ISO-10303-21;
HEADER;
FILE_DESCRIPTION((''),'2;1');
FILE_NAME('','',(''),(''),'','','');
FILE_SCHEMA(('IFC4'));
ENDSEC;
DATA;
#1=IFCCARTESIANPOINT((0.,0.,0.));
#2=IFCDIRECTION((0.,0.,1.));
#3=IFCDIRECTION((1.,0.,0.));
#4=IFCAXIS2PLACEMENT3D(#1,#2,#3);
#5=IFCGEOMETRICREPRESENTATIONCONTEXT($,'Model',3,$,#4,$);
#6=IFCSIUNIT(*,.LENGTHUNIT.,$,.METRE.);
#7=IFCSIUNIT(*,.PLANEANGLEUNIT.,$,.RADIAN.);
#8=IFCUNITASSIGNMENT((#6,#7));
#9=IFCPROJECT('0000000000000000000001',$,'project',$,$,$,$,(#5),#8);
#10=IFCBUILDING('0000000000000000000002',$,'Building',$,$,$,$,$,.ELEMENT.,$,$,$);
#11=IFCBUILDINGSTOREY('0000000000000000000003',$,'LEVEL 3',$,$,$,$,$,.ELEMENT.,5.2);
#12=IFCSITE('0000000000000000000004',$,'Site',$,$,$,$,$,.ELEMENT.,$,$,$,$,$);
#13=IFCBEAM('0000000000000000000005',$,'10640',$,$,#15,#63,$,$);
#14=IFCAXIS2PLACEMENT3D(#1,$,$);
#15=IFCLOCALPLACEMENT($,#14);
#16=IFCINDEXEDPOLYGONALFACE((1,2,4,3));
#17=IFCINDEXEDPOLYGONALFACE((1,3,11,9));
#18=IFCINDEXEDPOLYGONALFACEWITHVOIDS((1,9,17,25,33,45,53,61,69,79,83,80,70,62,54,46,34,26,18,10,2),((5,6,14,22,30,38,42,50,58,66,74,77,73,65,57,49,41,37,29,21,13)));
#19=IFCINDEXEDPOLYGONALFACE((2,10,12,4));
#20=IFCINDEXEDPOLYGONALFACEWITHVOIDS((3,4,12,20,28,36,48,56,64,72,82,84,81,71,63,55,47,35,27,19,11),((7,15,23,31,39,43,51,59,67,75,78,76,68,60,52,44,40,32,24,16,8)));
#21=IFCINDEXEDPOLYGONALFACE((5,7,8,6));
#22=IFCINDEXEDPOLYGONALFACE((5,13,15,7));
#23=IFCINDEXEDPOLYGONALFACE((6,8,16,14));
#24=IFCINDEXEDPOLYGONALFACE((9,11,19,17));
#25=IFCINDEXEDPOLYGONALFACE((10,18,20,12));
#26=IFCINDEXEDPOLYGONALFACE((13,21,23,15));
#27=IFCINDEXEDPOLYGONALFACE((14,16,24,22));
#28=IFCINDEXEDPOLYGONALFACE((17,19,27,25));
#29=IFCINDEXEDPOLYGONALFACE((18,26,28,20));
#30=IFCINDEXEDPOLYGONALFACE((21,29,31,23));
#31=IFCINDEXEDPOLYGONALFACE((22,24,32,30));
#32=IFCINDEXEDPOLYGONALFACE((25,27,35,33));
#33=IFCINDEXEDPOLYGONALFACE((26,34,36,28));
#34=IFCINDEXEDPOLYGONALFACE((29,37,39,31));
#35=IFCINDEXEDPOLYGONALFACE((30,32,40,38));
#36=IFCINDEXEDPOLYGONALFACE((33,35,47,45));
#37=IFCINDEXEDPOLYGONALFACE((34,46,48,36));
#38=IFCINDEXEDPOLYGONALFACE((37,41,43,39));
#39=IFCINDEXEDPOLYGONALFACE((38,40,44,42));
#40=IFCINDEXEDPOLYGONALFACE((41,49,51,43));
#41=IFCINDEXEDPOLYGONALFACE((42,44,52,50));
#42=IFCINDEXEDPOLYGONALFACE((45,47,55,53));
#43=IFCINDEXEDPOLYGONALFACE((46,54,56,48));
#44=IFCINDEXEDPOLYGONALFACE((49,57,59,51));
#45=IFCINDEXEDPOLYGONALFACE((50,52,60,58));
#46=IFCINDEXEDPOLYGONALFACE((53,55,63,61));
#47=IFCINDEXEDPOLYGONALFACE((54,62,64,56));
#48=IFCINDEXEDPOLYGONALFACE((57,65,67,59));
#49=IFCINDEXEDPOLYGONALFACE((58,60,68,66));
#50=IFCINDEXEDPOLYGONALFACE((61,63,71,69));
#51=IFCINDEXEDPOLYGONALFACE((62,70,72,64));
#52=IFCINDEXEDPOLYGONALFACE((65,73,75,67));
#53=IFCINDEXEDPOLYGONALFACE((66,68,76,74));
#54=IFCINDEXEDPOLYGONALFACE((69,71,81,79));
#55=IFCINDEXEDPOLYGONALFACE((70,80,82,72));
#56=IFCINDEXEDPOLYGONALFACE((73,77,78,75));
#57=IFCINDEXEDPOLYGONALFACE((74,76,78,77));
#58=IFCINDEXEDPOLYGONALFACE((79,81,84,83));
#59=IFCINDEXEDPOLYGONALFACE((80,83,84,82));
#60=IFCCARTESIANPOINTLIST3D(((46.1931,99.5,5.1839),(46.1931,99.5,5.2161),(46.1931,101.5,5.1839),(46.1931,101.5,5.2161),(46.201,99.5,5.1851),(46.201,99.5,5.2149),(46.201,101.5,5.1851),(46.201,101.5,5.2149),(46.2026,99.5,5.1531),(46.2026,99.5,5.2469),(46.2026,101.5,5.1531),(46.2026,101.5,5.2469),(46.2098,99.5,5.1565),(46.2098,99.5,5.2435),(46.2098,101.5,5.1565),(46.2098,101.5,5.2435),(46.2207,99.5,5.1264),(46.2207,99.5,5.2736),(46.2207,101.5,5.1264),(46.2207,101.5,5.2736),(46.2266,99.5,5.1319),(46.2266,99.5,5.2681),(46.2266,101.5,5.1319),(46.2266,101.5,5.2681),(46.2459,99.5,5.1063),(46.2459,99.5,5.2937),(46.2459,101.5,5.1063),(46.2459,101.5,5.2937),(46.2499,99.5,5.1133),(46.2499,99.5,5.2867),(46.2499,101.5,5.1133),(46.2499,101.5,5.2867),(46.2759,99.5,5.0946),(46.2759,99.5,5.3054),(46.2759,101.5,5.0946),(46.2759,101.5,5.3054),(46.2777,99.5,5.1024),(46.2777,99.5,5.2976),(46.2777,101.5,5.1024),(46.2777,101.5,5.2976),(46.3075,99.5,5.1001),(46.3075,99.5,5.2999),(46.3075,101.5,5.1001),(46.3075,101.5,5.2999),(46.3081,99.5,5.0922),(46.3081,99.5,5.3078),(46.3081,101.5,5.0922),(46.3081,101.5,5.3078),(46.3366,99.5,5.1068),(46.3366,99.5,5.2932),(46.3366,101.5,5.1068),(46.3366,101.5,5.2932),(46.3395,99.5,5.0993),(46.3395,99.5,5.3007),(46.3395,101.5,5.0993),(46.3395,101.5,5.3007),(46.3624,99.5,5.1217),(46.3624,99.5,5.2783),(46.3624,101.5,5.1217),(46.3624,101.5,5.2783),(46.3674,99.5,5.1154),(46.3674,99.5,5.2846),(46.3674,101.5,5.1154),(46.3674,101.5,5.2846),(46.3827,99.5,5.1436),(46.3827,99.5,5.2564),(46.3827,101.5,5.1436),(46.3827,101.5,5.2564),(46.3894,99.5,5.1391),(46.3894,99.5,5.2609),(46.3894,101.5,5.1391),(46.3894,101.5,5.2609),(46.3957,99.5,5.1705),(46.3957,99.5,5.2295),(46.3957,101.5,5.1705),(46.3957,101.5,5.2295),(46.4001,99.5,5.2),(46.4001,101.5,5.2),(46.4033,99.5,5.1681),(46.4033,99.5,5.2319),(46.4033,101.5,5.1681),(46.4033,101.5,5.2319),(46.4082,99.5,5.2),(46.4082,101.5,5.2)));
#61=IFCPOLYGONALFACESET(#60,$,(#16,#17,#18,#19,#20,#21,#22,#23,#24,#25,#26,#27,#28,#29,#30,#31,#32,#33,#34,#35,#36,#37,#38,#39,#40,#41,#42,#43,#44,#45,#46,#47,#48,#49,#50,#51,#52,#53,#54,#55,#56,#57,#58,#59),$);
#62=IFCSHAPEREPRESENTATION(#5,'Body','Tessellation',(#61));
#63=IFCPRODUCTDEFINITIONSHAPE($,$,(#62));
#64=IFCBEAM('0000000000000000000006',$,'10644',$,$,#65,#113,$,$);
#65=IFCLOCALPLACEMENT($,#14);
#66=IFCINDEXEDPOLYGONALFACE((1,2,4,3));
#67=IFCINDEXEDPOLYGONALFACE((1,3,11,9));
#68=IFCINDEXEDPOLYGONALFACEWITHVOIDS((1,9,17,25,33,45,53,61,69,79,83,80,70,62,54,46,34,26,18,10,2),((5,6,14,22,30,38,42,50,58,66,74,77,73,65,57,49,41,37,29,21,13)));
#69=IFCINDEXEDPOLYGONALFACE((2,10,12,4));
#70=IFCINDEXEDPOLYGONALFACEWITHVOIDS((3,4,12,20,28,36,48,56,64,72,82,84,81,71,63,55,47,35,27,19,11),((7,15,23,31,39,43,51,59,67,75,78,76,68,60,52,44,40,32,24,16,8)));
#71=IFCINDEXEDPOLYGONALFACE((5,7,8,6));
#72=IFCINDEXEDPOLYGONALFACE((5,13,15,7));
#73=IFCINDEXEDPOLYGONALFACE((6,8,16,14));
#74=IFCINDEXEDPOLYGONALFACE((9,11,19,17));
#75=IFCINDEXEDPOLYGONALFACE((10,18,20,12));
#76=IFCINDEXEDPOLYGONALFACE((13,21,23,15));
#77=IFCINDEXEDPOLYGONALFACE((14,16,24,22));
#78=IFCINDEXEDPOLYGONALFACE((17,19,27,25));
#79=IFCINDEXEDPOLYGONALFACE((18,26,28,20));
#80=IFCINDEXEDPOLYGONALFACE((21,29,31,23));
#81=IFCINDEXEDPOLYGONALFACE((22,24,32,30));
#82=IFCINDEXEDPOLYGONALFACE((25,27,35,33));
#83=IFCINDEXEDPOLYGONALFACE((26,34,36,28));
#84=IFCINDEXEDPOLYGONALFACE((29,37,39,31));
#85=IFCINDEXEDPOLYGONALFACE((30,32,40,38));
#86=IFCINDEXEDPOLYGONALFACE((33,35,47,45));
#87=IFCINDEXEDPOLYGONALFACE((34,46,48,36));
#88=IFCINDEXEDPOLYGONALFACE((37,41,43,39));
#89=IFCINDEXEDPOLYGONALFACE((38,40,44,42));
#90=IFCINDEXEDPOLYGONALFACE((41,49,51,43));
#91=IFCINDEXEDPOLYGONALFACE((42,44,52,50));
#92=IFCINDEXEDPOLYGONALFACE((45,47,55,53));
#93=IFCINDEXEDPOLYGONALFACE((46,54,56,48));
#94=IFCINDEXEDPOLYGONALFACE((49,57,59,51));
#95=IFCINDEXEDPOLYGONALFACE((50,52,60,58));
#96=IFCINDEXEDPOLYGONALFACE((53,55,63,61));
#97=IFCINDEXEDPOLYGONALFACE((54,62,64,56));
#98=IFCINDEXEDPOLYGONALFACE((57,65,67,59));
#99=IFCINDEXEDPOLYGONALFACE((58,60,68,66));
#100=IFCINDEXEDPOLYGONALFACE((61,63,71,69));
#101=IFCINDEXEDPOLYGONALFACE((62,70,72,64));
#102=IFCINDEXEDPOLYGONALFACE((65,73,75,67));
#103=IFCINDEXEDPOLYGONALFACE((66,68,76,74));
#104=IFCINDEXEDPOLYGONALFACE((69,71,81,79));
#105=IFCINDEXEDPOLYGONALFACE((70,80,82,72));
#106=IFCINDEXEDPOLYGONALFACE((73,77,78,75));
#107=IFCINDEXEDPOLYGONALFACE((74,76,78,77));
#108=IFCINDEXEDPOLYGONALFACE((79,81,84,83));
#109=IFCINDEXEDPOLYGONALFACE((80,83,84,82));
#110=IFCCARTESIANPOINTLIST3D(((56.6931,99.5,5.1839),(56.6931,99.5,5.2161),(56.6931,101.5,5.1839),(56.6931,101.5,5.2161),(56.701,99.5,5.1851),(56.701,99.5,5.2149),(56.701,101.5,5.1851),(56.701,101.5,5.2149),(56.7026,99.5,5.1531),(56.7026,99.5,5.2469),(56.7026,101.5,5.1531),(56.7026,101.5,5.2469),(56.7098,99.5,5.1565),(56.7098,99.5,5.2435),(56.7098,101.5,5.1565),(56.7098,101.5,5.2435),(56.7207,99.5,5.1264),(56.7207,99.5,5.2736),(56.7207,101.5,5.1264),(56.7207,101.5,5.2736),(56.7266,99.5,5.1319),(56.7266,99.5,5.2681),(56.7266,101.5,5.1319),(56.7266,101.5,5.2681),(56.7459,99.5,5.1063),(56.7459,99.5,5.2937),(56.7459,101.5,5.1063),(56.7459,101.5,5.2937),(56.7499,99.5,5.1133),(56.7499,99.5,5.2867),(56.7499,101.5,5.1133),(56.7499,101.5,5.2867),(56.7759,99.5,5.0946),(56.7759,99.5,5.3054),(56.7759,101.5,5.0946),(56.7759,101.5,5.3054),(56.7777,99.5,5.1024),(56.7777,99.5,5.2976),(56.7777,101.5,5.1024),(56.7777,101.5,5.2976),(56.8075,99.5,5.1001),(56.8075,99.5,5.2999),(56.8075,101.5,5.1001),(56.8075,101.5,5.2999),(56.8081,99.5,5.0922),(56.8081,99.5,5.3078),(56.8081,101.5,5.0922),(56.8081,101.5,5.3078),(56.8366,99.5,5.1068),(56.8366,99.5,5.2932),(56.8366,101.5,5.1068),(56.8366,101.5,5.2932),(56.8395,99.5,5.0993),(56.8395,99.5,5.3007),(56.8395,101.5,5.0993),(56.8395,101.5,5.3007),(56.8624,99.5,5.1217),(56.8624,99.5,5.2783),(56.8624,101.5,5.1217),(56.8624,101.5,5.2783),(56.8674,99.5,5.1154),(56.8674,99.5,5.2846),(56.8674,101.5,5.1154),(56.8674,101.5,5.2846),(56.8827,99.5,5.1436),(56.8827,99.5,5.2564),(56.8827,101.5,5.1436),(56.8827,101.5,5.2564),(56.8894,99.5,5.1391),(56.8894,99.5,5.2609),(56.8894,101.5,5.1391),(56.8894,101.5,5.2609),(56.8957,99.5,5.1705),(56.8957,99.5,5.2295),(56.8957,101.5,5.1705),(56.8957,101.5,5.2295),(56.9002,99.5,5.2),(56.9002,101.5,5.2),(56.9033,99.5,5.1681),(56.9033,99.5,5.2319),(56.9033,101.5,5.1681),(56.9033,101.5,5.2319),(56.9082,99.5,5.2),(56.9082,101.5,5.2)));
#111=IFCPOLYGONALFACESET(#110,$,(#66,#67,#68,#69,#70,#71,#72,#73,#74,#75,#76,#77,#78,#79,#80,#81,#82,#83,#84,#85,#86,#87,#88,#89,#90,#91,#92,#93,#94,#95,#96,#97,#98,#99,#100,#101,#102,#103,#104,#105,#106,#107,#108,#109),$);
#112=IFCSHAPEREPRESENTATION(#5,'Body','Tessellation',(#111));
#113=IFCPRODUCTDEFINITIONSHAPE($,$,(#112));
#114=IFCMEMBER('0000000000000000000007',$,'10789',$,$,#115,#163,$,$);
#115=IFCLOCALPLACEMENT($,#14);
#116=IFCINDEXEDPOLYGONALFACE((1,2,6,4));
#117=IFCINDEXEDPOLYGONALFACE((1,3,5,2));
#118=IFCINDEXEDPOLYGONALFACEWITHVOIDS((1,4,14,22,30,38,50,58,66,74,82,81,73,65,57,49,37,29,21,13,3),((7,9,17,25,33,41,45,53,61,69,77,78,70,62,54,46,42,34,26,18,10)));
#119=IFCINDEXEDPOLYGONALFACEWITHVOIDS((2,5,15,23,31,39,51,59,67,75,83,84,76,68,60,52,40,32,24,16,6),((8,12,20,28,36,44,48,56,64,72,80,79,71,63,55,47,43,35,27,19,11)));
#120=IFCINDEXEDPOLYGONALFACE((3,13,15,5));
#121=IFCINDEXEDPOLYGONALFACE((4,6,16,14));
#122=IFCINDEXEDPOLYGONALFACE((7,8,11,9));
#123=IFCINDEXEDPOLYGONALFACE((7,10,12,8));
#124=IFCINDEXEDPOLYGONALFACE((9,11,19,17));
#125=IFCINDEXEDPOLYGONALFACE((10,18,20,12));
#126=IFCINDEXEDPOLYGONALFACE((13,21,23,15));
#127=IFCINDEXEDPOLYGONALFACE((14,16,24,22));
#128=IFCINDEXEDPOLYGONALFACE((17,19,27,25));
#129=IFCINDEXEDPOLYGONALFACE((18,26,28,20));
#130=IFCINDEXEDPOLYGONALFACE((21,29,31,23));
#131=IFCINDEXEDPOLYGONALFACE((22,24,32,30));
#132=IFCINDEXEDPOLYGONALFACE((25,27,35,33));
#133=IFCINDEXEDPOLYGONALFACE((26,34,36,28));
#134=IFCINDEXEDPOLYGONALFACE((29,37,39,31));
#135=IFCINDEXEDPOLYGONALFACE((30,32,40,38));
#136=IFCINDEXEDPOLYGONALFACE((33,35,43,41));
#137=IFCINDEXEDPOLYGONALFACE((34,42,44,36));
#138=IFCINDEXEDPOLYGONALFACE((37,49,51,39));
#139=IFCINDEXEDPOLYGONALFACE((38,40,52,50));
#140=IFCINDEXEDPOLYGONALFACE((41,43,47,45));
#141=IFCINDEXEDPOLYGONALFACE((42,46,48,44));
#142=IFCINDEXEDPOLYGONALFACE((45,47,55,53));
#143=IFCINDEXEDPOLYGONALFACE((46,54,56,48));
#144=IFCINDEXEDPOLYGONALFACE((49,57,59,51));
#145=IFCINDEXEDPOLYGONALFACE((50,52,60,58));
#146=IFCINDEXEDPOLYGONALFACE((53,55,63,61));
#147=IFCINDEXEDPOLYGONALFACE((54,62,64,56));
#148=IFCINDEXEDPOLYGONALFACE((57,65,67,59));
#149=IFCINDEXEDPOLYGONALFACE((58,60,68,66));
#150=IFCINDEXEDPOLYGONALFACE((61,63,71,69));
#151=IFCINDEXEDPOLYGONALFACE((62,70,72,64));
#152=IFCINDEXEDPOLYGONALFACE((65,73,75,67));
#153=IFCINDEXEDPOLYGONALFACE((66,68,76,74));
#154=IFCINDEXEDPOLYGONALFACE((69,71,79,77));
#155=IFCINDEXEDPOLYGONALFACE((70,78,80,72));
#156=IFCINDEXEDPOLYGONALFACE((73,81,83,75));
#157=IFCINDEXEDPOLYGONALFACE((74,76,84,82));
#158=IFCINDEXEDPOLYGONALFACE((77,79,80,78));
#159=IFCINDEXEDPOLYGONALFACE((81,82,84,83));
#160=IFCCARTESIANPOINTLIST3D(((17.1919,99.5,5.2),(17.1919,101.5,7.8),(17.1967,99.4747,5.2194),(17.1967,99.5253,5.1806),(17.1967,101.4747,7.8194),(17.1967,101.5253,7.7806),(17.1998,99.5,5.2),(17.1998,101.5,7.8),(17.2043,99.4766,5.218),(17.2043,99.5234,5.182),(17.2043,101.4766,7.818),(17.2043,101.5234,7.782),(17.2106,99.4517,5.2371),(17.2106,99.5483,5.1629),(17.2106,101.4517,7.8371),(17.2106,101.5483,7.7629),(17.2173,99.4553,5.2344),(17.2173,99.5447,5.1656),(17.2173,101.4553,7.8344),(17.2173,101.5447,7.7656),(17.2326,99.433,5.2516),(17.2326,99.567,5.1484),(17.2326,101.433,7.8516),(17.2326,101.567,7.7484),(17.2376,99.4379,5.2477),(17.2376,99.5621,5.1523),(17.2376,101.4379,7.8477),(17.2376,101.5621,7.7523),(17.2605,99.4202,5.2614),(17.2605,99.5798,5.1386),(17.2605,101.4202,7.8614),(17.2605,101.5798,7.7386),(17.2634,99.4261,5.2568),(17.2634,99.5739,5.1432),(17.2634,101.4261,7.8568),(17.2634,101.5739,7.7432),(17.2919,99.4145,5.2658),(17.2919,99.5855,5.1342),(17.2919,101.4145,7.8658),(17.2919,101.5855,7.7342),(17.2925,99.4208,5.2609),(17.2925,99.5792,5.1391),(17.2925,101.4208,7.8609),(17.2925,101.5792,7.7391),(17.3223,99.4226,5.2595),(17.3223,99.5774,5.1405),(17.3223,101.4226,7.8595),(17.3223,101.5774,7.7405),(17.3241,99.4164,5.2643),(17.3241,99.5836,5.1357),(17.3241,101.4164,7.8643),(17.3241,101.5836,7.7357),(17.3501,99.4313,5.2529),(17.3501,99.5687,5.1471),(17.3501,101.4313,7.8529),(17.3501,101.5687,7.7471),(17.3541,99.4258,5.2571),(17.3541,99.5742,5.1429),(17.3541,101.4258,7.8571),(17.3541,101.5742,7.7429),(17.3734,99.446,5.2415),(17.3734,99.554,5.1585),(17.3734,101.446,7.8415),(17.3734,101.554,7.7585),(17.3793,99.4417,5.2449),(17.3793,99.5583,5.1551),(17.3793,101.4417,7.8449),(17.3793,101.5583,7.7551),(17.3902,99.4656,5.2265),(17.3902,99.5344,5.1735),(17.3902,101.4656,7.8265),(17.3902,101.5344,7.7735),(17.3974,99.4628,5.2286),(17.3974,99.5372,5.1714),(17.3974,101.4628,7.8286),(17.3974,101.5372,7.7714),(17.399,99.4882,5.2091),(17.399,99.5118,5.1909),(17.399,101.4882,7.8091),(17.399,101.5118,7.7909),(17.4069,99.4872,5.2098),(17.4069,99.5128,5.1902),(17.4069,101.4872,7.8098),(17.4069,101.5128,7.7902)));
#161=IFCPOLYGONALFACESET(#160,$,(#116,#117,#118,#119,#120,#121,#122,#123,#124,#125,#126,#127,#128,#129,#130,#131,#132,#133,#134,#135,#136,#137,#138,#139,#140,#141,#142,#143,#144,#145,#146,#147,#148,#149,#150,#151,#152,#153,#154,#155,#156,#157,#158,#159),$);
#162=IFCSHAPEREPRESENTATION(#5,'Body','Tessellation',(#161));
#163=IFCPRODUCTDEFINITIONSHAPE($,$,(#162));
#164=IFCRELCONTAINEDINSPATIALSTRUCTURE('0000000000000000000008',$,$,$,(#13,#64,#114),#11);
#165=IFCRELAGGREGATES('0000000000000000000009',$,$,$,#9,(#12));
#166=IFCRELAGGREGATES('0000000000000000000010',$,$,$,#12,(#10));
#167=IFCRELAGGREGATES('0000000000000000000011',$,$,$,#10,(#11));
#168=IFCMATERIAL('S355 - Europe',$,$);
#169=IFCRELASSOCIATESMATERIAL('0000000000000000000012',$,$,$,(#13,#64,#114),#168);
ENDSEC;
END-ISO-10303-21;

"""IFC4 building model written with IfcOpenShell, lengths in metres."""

from ifc_helpers import new_model, si_unit, frame, origin_with_axes, origin_2d_with_axis, place, context, project, spatial, hollow_circle, extrude, material, material_profile, profile_set, profile_usage, element, save


model = new_model("IFC4")

# Units and contexts
model_context = context("Model", 3, world=origin_with_axes())
ifc_project = project(units=[si_unit("LENGTHUNIT", "METRE"), si_unit("PLANEANGLEUNIT", "RADIAN")], contexts=[model_context])

# Site, building, storey
site = spatial("IfcSite", under=ifc_project, Name="Site", CompositionType="ELEMENT")
building = spatial("IfcBuilding", under=site, Name="Building", CompositionType="ELEMENT")
storey = spatial("IfcBuildingStorey", under=building, Name="LEVEL 3", CompositionType="ELEMENT", Elevation=5.2)

# Shared definitions
ifc_material = material(Name="S355 - Europe")

# Beams
ifc_material_profile_1 = material_profile(ifc_material, hollow_circle(Radius=0.1081, WallThickness=0.008, at=origin_2d_with_axis()))
ifc_profile_set_1 = profile_set([ifc_material_profile_1])
ifc_profile_usage_1 = profile_usage(ifc_profile_set_1, cardinal=10)
beam_1_placement = place(None, frame((46.3, 101.5, 5.2), z_axis=(0.0, -1.0, 0.0), x_axis=(1.0, 0.0, 0.0)))
element("IfcBeam", 1, at=beam_1_placement, inside=storey, material=ifc_profile_usage_1, Name="10640", context=model_context, shape_type="SweptSolid", body=[
    extrude(hollow_circle(Radius=0.1081, WallThickness=0.008, at=origin_2d_with_axis()), origin_with_axes(), (0.0, 0.0, 1.0), 2.0),
])
ifc_material_profile_2 = material_profile(ifc_material, hollow_circle(Radius=0.1081, WallThickness=0.008, at=origin_2d_with_axis()))
ifc_profile_set_2 = profile_set([ifc_material_profile_2])
ifc_profile_usage_2 = profile_usage(ifc_profile_set_2, cardinal=10)
beam_2_placement = place(None, frame((56.8, 101.5, 5.2), z_axis=(0.0, -1.0, 0.0), x_axis=(1.0, 0.0, 0.0)))
element("IfcBeam", 2, at=beam_2_placement, inside=storey, material=ifc_profile_usage_2, Name="10644", context=model_context, shape_type="SweptSolid", body=[
    extrude(hollow_circle(Radius=0.1081, WallThickness=0.008, at=origin_2d_with_axis()), origin_with_axes(), (0.0, 0.0, 1.0), 2.0),
])

# Member
ifc_material_profile_3 = material_profile(ifc_material, hollow_circle(Radius=0.1081, WallThickness=0.008, at=origin_2d_with_axis()))
ifc_profile_set_3 = profile_set([ifc_material_profile_3])
ifc_profile_usage_3 = profile_usage(ifc_profile_set_3, cardinal=10)
member_1_placement = place(None, frame((17.3, 99.5, 5.2), z_axis=(0.0, 0.609711, 0.792624), x_axis=(-1.0, 0.0, 0.0)))
element("IfcMember", 3, at=member_1_placement, inside=storey, material=ifc_profile_usage_3, Name="10789", context=model_context, shape_type="SweptSolid", body=[
    extrude(hollow_circle(Radius=0.1081, WallThickness=0.008, at=origin_2d_with_axis()), origin_with_axes(), (0.0, 0.0, 1.0), 3.2802),
])

save(model, "model.ifc")
